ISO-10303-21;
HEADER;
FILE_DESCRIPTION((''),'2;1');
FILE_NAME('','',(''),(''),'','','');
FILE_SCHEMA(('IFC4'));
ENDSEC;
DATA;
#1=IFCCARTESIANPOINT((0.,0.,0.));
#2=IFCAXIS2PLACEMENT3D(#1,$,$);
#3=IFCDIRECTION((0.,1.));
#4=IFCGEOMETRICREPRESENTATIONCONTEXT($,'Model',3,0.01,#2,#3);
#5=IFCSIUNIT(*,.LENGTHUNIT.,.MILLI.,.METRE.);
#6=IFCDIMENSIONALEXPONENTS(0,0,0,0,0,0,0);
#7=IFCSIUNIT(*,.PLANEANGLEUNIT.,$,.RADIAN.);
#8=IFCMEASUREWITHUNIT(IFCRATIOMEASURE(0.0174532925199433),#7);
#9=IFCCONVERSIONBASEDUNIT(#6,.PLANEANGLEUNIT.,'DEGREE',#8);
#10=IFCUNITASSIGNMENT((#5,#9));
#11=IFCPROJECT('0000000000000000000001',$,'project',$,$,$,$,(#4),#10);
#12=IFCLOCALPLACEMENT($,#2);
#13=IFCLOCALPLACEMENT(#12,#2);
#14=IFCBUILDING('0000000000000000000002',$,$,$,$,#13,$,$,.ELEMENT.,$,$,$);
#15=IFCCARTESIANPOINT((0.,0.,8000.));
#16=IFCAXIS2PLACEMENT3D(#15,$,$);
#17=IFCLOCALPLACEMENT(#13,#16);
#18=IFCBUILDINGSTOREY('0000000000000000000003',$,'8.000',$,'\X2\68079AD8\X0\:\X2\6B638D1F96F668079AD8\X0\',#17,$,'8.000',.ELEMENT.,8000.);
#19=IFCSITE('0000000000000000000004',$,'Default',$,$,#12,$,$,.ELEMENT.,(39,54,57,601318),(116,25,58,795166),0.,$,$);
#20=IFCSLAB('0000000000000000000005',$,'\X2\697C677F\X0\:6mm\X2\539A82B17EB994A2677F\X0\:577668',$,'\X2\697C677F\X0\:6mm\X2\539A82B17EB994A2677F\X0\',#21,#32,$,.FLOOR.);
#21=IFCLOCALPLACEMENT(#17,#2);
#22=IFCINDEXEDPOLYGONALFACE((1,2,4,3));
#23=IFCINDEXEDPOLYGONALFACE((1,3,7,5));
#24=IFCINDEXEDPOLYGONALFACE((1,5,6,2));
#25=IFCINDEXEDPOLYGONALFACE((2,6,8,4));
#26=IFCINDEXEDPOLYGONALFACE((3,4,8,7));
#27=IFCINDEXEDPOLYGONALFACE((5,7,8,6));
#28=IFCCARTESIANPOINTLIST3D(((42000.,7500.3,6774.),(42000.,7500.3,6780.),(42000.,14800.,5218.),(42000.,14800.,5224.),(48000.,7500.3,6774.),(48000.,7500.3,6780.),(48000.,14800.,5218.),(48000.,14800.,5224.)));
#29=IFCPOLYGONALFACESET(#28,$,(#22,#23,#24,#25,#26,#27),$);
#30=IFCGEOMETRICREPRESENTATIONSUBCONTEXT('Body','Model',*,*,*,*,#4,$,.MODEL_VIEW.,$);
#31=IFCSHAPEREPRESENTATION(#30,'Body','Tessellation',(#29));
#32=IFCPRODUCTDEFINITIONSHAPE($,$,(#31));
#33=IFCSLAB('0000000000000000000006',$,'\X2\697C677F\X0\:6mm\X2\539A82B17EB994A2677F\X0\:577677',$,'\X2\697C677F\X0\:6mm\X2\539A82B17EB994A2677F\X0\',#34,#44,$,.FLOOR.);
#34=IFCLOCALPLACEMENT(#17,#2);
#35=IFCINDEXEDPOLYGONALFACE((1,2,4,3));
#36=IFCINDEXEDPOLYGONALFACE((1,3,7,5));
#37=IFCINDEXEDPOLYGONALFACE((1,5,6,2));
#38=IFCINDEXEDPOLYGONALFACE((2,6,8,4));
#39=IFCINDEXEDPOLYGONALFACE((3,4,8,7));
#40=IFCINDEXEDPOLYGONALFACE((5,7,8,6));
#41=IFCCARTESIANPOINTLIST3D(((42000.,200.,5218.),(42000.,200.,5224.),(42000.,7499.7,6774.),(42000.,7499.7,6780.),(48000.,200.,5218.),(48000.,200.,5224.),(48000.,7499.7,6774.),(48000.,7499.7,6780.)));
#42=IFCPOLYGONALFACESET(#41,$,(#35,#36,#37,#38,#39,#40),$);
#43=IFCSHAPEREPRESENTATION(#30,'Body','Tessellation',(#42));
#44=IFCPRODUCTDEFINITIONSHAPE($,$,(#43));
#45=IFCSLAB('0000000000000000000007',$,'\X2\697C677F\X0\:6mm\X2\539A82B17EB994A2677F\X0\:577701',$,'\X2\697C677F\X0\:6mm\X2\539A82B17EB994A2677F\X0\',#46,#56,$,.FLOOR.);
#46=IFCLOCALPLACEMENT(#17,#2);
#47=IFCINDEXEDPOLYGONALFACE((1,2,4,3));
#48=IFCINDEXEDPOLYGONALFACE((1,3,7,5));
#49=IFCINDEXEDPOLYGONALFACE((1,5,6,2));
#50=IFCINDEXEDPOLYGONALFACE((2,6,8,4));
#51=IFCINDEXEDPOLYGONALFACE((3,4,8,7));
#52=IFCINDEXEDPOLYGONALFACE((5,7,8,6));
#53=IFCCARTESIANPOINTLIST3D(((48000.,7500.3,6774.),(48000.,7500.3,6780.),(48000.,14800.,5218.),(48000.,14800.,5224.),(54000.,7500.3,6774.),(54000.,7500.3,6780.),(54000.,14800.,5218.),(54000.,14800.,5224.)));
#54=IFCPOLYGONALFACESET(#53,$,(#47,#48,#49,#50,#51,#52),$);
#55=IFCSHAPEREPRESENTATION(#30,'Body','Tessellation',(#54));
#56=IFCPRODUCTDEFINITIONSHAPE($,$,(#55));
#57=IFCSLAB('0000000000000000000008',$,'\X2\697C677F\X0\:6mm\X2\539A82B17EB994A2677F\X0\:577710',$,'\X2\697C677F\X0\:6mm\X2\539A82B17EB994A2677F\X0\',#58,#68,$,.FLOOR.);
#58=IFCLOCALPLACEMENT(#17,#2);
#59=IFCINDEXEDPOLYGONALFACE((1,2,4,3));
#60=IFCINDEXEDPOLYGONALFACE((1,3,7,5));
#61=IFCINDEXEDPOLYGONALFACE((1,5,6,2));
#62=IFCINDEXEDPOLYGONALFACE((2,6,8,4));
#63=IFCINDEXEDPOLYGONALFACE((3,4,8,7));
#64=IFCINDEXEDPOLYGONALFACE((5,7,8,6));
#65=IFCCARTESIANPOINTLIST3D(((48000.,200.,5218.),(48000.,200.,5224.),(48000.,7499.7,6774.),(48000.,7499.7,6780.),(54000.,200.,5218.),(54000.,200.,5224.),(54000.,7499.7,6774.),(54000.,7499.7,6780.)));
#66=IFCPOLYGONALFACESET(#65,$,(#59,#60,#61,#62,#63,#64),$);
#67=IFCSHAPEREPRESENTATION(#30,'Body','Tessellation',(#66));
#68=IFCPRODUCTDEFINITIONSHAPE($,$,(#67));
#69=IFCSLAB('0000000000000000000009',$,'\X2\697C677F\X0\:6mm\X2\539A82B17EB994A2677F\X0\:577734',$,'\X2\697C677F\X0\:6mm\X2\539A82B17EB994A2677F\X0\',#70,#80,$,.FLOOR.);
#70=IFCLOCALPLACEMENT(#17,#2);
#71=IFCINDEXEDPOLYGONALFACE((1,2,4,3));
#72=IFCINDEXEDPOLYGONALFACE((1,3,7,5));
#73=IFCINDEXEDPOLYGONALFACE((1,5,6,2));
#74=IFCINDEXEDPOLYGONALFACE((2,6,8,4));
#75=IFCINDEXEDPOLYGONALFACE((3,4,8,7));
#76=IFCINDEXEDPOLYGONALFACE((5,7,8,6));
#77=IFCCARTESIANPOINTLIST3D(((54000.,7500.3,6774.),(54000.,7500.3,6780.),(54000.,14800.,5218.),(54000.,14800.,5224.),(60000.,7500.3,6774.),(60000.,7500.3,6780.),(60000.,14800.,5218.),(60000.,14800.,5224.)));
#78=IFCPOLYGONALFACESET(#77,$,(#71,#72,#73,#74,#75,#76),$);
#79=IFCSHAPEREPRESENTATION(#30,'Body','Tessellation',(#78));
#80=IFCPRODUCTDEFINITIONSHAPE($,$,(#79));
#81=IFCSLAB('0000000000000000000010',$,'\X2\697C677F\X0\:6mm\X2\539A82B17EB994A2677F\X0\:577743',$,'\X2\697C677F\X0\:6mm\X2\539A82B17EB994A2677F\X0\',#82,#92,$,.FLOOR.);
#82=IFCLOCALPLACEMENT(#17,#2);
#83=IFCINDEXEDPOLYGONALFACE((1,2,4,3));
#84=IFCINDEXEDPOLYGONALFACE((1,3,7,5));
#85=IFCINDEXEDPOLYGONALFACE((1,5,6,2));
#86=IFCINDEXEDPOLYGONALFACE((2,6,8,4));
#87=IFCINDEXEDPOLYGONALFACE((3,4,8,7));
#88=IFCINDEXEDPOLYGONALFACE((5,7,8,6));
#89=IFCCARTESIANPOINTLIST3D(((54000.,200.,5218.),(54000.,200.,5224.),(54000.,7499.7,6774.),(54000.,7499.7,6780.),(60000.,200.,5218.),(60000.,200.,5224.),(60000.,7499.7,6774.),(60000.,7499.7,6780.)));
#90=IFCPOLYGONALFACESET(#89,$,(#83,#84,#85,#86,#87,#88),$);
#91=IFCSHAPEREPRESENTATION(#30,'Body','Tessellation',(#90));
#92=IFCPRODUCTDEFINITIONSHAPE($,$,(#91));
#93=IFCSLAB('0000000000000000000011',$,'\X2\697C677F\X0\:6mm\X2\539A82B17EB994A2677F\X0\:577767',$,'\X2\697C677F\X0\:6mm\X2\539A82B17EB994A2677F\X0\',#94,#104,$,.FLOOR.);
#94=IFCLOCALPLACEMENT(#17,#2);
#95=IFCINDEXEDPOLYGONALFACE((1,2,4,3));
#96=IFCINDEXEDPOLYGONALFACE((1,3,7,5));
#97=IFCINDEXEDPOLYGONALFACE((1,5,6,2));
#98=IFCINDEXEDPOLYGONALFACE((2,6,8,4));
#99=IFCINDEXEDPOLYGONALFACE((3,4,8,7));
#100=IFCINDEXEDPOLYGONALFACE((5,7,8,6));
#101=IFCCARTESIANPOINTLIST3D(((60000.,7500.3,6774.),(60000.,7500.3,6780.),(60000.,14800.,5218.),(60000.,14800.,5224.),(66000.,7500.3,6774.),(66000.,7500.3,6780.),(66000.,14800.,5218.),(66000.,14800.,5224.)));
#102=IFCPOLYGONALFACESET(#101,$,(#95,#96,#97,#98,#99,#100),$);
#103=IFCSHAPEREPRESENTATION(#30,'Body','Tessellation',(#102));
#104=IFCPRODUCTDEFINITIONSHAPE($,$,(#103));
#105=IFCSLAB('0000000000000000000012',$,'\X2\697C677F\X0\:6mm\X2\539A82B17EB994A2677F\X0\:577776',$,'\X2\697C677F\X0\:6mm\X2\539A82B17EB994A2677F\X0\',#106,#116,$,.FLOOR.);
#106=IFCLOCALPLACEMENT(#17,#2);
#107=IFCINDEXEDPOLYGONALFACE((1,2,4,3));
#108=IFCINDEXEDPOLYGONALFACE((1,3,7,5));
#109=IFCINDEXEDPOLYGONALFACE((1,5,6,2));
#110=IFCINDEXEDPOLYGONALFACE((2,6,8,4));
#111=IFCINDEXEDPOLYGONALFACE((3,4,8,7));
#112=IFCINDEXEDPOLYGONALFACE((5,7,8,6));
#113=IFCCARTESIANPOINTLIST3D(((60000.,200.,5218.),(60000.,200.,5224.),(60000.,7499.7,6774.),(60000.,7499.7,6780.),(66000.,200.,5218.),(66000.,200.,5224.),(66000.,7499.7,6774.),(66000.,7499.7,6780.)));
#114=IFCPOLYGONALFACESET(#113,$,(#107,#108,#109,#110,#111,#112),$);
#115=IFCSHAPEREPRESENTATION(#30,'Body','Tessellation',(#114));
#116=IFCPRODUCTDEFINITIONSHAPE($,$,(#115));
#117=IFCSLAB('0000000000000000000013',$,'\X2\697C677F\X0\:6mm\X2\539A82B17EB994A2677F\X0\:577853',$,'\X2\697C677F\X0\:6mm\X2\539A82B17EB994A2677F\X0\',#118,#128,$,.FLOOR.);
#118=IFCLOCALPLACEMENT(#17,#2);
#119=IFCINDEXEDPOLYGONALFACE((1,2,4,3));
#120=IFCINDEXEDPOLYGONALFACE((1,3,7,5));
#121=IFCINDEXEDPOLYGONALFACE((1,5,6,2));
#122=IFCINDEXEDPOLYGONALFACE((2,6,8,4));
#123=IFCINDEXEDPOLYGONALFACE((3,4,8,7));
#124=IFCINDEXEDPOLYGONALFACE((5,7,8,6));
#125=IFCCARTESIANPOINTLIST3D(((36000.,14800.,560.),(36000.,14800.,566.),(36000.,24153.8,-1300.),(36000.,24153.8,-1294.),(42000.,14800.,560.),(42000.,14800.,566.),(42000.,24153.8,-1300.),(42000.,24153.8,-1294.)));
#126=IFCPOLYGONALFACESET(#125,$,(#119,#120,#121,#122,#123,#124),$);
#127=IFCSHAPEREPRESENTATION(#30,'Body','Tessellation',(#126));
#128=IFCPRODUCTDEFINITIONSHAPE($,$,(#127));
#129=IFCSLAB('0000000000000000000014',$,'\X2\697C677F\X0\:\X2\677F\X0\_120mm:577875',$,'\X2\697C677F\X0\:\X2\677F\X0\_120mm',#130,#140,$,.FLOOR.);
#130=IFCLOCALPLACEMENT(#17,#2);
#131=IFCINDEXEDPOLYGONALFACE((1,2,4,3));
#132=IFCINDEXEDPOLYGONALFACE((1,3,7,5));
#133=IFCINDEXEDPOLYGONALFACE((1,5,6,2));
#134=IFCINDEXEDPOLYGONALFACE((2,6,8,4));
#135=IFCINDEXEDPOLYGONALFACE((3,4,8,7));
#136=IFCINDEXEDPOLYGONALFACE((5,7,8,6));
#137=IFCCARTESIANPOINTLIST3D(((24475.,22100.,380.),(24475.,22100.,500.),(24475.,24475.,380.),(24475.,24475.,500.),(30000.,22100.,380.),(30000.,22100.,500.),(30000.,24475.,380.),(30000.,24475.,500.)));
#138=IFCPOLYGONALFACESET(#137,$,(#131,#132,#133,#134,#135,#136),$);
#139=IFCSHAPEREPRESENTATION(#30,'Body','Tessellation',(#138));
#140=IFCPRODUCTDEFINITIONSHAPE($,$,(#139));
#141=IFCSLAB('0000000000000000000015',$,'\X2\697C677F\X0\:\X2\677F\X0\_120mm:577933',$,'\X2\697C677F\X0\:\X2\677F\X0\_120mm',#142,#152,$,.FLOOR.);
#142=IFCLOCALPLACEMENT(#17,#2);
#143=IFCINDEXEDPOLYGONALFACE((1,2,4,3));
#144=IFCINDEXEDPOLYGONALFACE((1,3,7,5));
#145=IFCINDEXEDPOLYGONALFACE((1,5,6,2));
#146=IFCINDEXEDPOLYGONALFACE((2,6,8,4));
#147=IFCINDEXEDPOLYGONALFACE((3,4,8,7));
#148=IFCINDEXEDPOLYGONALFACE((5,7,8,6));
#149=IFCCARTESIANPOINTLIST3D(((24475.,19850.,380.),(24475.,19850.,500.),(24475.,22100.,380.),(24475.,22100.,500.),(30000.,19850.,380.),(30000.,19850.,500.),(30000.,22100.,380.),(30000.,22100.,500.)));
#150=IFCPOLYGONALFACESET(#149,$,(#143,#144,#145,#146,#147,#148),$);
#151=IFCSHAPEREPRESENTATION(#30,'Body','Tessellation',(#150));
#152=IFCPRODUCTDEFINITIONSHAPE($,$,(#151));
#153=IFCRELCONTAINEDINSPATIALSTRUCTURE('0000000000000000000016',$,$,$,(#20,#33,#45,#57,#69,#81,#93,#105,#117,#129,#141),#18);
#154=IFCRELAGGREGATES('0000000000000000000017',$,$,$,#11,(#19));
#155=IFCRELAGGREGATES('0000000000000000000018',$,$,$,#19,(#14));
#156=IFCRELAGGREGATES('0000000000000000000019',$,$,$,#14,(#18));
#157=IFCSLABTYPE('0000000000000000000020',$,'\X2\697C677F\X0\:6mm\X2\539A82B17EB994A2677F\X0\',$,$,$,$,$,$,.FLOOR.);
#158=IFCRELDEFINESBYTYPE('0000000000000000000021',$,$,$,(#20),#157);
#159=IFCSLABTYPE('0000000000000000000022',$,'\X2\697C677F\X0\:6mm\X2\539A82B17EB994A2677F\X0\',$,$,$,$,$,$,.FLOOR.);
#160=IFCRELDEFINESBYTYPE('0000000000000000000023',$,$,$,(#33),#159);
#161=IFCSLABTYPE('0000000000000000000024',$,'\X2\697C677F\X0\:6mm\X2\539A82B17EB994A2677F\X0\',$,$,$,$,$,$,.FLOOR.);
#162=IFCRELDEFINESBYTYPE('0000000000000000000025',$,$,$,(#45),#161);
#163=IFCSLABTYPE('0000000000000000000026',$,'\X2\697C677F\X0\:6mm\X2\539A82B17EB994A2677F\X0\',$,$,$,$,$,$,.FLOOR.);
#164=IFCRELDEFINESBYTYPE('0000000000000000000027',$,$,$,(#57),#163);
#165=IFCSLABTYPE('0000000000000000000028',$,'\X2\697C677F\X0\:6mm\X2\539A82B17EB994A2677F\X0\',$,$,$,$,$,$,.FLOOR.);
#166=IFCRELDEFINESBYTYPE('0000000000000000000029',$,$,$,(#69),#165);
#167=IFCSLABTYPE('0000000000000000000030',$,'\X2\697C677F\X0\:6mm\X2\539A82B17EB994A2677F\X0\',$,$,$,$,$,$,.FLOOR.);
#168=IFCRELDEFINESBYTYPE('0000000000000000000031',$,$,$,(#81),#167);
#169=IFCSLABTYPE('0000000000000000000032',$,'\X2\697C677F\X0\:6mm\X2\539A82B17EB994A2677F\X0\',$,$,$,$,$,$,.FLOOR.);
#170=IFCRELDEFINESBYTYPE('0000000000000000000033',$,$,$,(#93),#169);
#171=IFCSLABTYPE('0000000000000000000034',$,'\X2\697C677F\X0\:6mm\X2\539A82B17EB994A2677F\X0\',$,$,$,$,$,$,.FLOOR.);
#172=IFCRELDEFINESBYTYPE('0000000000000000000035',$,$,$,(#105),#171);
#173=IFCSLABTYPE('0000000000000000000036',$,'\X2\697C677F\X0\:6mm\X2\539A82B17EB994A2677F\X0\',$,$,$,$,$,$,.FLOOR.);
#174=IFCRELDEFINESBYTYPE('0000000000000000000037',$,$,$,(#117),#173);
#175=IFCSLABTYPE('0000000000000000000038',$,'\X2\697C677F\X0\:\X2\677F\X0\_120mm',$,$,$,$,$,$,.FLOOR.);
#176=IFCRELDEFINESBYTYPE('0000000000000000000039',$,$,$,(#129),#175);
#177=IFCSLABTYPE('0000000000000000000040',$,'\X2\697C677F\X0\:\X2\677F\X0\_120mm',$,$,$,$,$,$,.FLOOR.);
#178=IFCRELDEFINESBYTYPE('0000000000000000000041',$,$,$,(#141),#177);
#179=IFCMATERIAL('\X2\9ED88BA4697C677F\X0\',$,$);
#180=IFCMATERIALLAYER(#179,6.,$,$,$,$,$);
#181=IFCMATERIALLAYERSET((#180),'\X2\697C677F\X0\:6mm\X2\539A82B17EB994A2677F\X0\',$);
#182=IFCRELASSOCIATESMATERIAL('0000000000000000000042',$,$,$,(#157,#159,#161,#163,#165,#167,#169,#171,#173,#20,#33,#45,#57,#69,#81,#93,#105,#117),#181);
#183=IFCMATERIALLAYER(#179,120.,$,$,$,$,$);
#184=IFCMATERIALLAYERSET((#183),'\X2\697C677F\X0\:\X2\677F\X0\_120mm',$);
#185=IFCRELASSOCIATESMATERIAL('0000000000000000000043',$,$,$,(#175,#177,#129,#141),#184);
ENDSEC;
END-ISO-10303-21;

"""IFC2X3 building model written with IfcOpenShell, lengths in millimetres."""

from ifc_helpers import new_model, entity, si_unit, converted_unit, direction, frame, frame_2d, origin, origin_2d_with_axis, place, context, subcontext, project, spatial, rectangle, extrude, clip, halfspace, material, layer, layer_set, layer_usage, type_object, element, save


model = new_model("IFC2X3")

# Units and contexts
model_context = context("Model", 3, precision=0.01, world=origin(), true_north=direction((0.0, 1.0)))
body_context = subcontext(model_context, "Body", "Model", "MODEL_VIEW")
ifc_project = project(units=[si_unit("LENGTHUNIT", "METRE", prefix="MILLI"), converted_unit("PLANEANGLEUNIT", "DEGREE", entity("IfcRatioMeasure", 0.0174532925199433), si_unit("PLANEANGLEUNIT", "RADIAN"), dimensions=[0, 0, 0, 0, 0, 0, 0])], contexts=[model_context])

# Site, building, storey
site_placement = place(None, origin())
site = spatial("IfcSite", under=ifc_project, at=site_placement, Name="Default", CompositionType="ELEMENT", RefLatitude=(39, 54, 57, 601318), RefLongitude=(116, 25, 58, 795166), RefElevation=0.0)
building_placement = place(site_placement, origin())
building = spatial("IfcBuilding", under=site, at=building_placement, CompositionType="ELEMENT")
storey_placement = place(building_placement, frame((0.0, 0.0, 8000.0)))
storey = spatial("IfcBuildingStorey", under=building, at=storey_placement, Name="8.000", ObjectType="标高:正负零标高", LongName="8.000", CompositionType="ELEMENT", Elevation=8000.0)

# Slabs
ifc_material_1 = material(Name="默认楼板")
ifc_layer_1 = layer(ifc_material_1, 6.0)
ifc_layer_set_1 = layer_set([ifc_layer_1], Name="楼板:6mm厚花纹钢板")
ifc_layer_usage_1 = layer_usage(ifc_layer_set_1, "AXIS3", "POSITIVE", 0.0)
slab_type_1 = type_object("IfcSlabType", Name="楼板:6mm厚花纹钢板", PredefinedType="FLOOR", material=ifc_layer_set_1)
slab_1_placement = place(storey_placement, origin())
element("IfcSlab", 1, at=slab_1_placement, inside=storey, type_object=slab_type_1, material=ifc_layer_usage_1, Name="楼板:6mm厚花纹钢板:577668", ObjectType="楼板:6mm厚花纹钢板", PredefinedType="FLOOR", context=body_context, shape_type="Clipping", body=[
    clip(clip(extrude(rectangle(XDim=7463.7, YDim=6000.0, at=origin_2d_with_axis()), frame((45000.0, 11150.2, 6002.0), z_axis=(0.0, -0.208477, -0.978027), x_axis=(0.0, 0.978027, -0.208477)), (0.208477, 0.0, 0.978027), 6.1), halfspace(frame((45000.0, 11150.2, 5996.0), z_axis=(0.0, -0.208477, -0.978027), x_axis=(0.0, -0.978027, 0.208477)), False)), halfspace(frame((45000.0, 11150.2, 6002.0), z_axis=(0.0, 0.208477, 0.978027), x_axis=(0.0, -0.978027, 0.208477)), False)),
])
ifc_layer_usage_2 = layer_usage(ifc_layer_set_1, "AXIS3", "POSITIVE", 0.0)
slab_type_2 = type_object("IfcSlabType", Name="楼板:6mm厚花纹钢板", PredefinedType="FLOOR", material=ifc_layer_set_1)
slab_2_placement = place(storey_placement, origin())
element("IfcSlab", 2, at=slab_2_placement, inside=storey, type_object=slab_type_2, material=ifc_layer_usage_2, Name="楼板:6mm厚花纹钢板:577677", ObjectType="楼板:6mm厚花纹钢板", PredefinedType="FLOOR", context=body_context, shape_type="Clipping", body=[
    clip(clip(extrude(rectangle(XDim=7463.7, YDim=6000.0, at=origin_2d_with_axis()), frame((45000.0, 3849.8, 6002.0), z_axis=(0.0, 0.208477, -0.978027), x_axis=(0.0, 0.978027, 0.208477)), (-0.208477, 0.0, 0.978027), 6.1), halfspace(frame((45000.0, 3849.8, 5996.0), z_axis=(0.0, 0.208477, -0.978027), x_axis=(0.0, -0.978027, -0.208477)), False)), halfspace(frame((45000.0, 3849.8, 6002.0), z_axis=(0.0, -0.208477, 0.978027), x_axis=(0.0, -0.978027, -0.208477)), False)),
])
ifc_layer_usage_3 = layer_usage(ifc_layer_set_1, "AXIS3", "POSITIVE", 0.0)
slab_type_3 = type_object("IfcSlabType", Name="楼板:6mm厚花纹钢板", PredefinedType="FLOOR", material=ifc_layer_set_1)
slab_3_placement = place(storey_placement, origin())
element("IfcSlab", 3, at=slab_3_placement, inside=storey, type_object=slab_type_3, material=ifc_layer_usage_3, Name="楼板:6mm厚花纹钢板:577701", ObjectType="楼板:6mm厚花纹钢板", PredefinedType="FLOOR", context=body_context, shape_type="Clipping", body=[
    clip(clip(extrude(rectangle(XDim=7463.7, YDim=6000.0, at=origin_2d_with_axis()), frame((51000.0, 11150.2, 6002.0), z_axis=(0.0, -0.208477, -0.978027), x_axis=(0.0, 0.978027, -0.208477)), (0.208477, 0.0, 0.978027), 6.1), halfspace(frame((51000.0, 11150.2, 5996.0), z_axis=(0.0, -0.208477, -0.978027), x_axis=(0.0, -0.978027, 0.208477)), False)), halfspace(frame((51000.0, 11150.2, 6002.0), z_axis=(0.0, 0.208477, 0.978027), x_axis=(0.0, -0.978027, 0.208477)), False)),
])
ifc_layer_usage_4 = layer_usage(ifc_layer_set_1, "AXIS3", "POSITIVE", 0.0)
slab_type_4 = type_object("IfcSlabType", Name="楼板:6mm厚花纹钢板", PredefinedType="FLOOR", material=ifc_layer_set_1)
slab_4_placement = place(storey_placement, origin())
element("IfcSlab", 4, at=slab_4_placement, inside=storey, type_object=slab_type_4, material=ifc_layer_usage_4, Name="楼板:6mm厚花纹钢板:577710", ObjectType="楼板:6mm厚花纹钢板", PredefinedType="FLOOR", context=body_context, shape_type="Clipping", body=[
    clip(clip(extrude(rectangle(XDim=7463.7, YDim=6000.0, at=origin_2d_with_axis()), frame((51000.0, 3849.8, 6002.0), z_axis=(0.0, 0.208477, -0.978027), x_axis=(0.0, 0.978027, 0.208477)), (-0.208477, 0.0, 0.978027), 6.1), halfspace(frame((51000.0, 3849.8, 5996.0), z_axis=(0.0, 0.208477, -0.978027), x_axis=(0.0, -0.978027, -0.208477)), False)), halfspace(frame((51000.0, 3849.8, 6002.0), z_axis=(0.0, -0.208477, 0.978027), x_axis=(0.0, -0.978027, -0.208477)), False)),
])
ifc_layer_usage_5 = layer_usage(ifc_layer_set_1, "AXIS3", "POSITIVE", 0.0)
slab_type_5 = type_object("IfcSlabType", Name="楼板:6mm厚花纹钢板", PredefinedType="FLOOR", material=ifc_layer_set_1)
slab_5_placement = place(storey_placement, origin())
element("IfcSlab", 5, at=slab_5_placement, inside=storey, type_object=slab_type_5, material=ifc_layer_usage_5, Name="楼板:6mm厚花纹钢板:577734", ObjectType="楼板:6mm厚花纹钢板", PredefinedType="FLOOR", context=body_context, shape_type="Clipping", body=[
    clip(clip(extrude(rectangle(XDim=7463.7, YDim=6000.0, at=frame_2d((0.0, 0.0), x_axis=(1.0, 0.0))), frame((57000.0, 11150.2, 6002.0), z_axis=(0.0, -0.208477, -0.978027), x_axis=(0.0, 0.978027, -0.208477)), (0.208477, 0.0, 0.978027), 6.1), halfspace(frame((57000.0, 11150.2, 5996.0), z_axis=(0.0, -0.208477, -0.978027), x_axis=(0.0, -0.978027, 0.208477)), False)), halfspace(frame((57000.0, 11150.2, 6002.0), z_axis=(0.0, 0.208477, 0.978027), x_axis=(0.0, -0.978027, 0.208477)), False)),
])
ifc_layer_usage_6 = layer_usage(ifc_layer_set_1, "AXIS3", "POSITIVE", 0.0)
slab_type_6 = type_object("IfcSlabType", Name="楼板:6mm厚花纹钢板", PredefinedType="FLOOR", material=ifc_layer_set_1)
slab_6_placement = place(storey_placement, origin())
element("IfcSlab", 6, at=slab_6_placement, inside=storey, type_object=slab_type_6, material=ifc_layer_usage_6, Name="楼板:6mm厚花纹钢板:577743", ObjectType="楼板:6mm厚花纹钢板", PredefinedType="FLOOR", context=body_context, shape_type="Clipping", body=[
    clip(clip(extrude(rectangle(XDim=7463.7, YDim=6000.0, at=origin_2d_with_axis()), frame((57000.0, 3849.8, 6002.0), z_axis=(0.0, 0.208477, -0.978027), x_axis=(0.0, 0.978027, 0.208477)), (-0.208477, 0.0, 0.978027), 6.1), halfspace(frame((57000.0, 3849.8, 5996.0), z_axis=(0.0, 0.208477, -0.978027), x_axis=(0.0, -0.978027, -0.208477)), False)), halfspace(frame((57000.0, 3849.8, 6002.0), z_axis=(0.0, -0.208477, 0.978027), x_axis=(0.0, -0.978027, -0.208477)), False)),
])
ifc_layer_usage_7 = layer_usage(ifc_layer_set_1, "AXIS3", "POSITIVE", 0.0)
slab_type_7 = type_object("IfcSlabType", Name="楼板:6mm厚花纹钢板", PredefinedType="FLOOR", material=ifc_layer_set_1)
slab_7_placement = place(storey_placement, origin())
element("IfcSlab", 7, at=slab_7_placement, inside=storey, type_object=slab_type_7, material=ifc_layer_usage_7, Name="楼板:6mm厚花纹钢板:577767", ObjectType="楼板:6mm厚花纹钢板", PredefinedType="FLOOR", context=body_context, shape_type="Clipping", body=[
    clip(clip(extrude(rectangle(XDim=7463.7, YDim=6000.0, at=origin_2d_with_axis()), frame((63000.0, 11150.2, 6002.0), z_axis=(0.0, -0.208477, -0.978027), x_axis=(0.0, 0.978027, -0.208477)), (0.208477, 0.0, 0.978027), 6.1), halfspace(frame((63000.0, 11150.2, 5996.0), z_axis=(0.0, -0.208477, -0.978027), x_axis=(0.0, -0.978027, 0.208477)), False)), halfspace(frame((63000.0, 11150.2, 6002.0), z_axis=(0.0, 0.208477, 0.978027), x_axis=(0.0, -0.978027, 0.208477)), False)),
])
ifc_layer_usage_8 = layer_usage(ifc_layer_set_1, "AXIS3", "POSITIVE", 0.0)
slab_type_8 = type_object("IfcSlabType", Name="楼板:6mm厚花纹钢板", PredefinedType="FLOOR", material=ifc_layer_set_1)
slab_8_placement = place(storey_placement, origin())
element("IfcSlab", 8, at=slab_8_placement, inside=storey, type_object=slab_type_8, material=ifc_layer_usage_8, Name="楼板:6mm厚花纹钢板:577776", ObjectType="楼板:6mm厚花纹钢板", PredefinedType="FLOOR", context=body_context, shape_type="Clipping", body=[
    clip(clip(extrude(rectangle(XDim=7463.7, YDim=6000.0, at=origin_2d_with_axis()), frame((63000.0, 3849.8, 6002.0), z_axis=(0.0, 0.208477, -0.978027), x_axis=(0.0, 0.978027, 0.208477)), (-0.208477, 0.0, 0.978027), 6.1), halfspace(frame((63000.0, 3849.8, 5996.0), z_axis=(0.0, 0.208477, -0.978027), x_axis=(0.0, -0.978027, -0.208477)), False)), halfspace(frame((63000.0, 3849.8, 6002.0), z_axis=(0.0, -0.208477, 0.978027), x_axis=(0.0, -0.978027, -0.208477)), False)),
])
ifc_layer_usage_9 = layer_usage(ifc_layer_set_1, "AXIS3", "POSITIVE", 0.0)
slab_type_9 = type_object("IfcSlabType", Name="楼板:6mm厚花纹钢板", PredefinedType="FLOOR", material=ifc_layer_set_1)
slab_9_placement = place(storey_placement, origin())
element("IfcSlab", 9, at=slab_9_placement, inside=storey, type_object=slab_type_9, material=ifc_layer_usage_9, Name="楼板:6mm厚花纹钢板:577853", ObjectType="楼板:6mm厚花纹钢板", PredefinedType="FLOOR", context=body_context, shape_type="Clipping", body=[
    clip(clip(extrude(rectangle(XDim=9536.9, YDim=6000.0, at=frame_2d((0.0, 0.0), x_axis=(1.0, 0.0))), frame((39000.0, 19476.9, -364.0), z_axis=(0.0, -0.195031, -0.980797), x_axis=(0.0, 0.980797, -0.195031)), (0.195031, 0.0, 0.980797), 6.1), halfspace(frame((39000.0, 19476.9, -370.0), z_axis=(0.0, -0.195031, -0.980797), x_axis=(0.0, -0.980797, 0.195031)), False)), halfspace(frame((39000.0, 19476.9, -364.0), z_axis=(0.0, 0.195031, 0.980797), x_axis=(0.0, -0.980797, 0.195031)), False)),
])
ifc_layer_2 = layer(ifc_material_1, 120.0)
ifc_layer_set_2 = layer_set([ifc_layer_2], Name="楼板:板_120mm")
ifc_layer_usage_10 = layer_usage(ifc_layer_set_2, "AXIS3", "POSITIVE", 0.0)
slab_type_10 = type_object("IfcSlabType", Name="楼板:板_120mm", PredefinedType="FLOOR", material=ifc_layer_set_2)
slab_10_placement = place(storey_placement, origin())
element("IfcSlab", 10, at=slab_10_placement, inside=storey, type_object=slab_type_10, material=ifc_layer_usage_10, Name="楼板:板_120mm:577875", ObjectType="楼板:板_120mm", PredefinedType="FLOOR", context=body_context, shape_type="SweptSolid", body=[
    extrude(rectangle(XDim=2375.0, YDim=5525.0, at=origin_2d_with_axis()), frame((27237.5, 23287.5, 500.0), z_axis=(0.0, 0.0, -1.0), x_axis=(0.0, 1.0, 0.0)), (0.0, 0.0, 1.0), 120.0),
])
ifc_layer_usage_11 = layer_usage(ifc_layer_set_2, "AXIS3", "POSITIVE", 0.0)
slab_type_11 = type_object("IfcSlabType", Name="楼板:板_120mm", PredefinedType="FLOOR", material=ifc_layer_set_2)
slab_11_placement = place(storey_placement, origin())
element("IfcSlab", 11, at=slab_11_placement, inside=storey, type_object=slab_type_11, material=ifc_layer_usage_11, Name="楼板:板_120mm:577933", ObjectType="楼板:板_120mm", PredefinedType="FLOOR", context=body_context, shape_type="SweptSolid", body=[
    extrude(rectangle(XDim=2250.0, YDim=5525.0, at=origin_2d_with_axis()), frame((27237.5, 20975.0, 500.0), z_axis=(0.0, 0.0, -1.0), x_axis=(0.0, 1.0, 0.0)), (0.0, 0.0, 1.0), 120.0),
])

save(model, "model.ifc")
